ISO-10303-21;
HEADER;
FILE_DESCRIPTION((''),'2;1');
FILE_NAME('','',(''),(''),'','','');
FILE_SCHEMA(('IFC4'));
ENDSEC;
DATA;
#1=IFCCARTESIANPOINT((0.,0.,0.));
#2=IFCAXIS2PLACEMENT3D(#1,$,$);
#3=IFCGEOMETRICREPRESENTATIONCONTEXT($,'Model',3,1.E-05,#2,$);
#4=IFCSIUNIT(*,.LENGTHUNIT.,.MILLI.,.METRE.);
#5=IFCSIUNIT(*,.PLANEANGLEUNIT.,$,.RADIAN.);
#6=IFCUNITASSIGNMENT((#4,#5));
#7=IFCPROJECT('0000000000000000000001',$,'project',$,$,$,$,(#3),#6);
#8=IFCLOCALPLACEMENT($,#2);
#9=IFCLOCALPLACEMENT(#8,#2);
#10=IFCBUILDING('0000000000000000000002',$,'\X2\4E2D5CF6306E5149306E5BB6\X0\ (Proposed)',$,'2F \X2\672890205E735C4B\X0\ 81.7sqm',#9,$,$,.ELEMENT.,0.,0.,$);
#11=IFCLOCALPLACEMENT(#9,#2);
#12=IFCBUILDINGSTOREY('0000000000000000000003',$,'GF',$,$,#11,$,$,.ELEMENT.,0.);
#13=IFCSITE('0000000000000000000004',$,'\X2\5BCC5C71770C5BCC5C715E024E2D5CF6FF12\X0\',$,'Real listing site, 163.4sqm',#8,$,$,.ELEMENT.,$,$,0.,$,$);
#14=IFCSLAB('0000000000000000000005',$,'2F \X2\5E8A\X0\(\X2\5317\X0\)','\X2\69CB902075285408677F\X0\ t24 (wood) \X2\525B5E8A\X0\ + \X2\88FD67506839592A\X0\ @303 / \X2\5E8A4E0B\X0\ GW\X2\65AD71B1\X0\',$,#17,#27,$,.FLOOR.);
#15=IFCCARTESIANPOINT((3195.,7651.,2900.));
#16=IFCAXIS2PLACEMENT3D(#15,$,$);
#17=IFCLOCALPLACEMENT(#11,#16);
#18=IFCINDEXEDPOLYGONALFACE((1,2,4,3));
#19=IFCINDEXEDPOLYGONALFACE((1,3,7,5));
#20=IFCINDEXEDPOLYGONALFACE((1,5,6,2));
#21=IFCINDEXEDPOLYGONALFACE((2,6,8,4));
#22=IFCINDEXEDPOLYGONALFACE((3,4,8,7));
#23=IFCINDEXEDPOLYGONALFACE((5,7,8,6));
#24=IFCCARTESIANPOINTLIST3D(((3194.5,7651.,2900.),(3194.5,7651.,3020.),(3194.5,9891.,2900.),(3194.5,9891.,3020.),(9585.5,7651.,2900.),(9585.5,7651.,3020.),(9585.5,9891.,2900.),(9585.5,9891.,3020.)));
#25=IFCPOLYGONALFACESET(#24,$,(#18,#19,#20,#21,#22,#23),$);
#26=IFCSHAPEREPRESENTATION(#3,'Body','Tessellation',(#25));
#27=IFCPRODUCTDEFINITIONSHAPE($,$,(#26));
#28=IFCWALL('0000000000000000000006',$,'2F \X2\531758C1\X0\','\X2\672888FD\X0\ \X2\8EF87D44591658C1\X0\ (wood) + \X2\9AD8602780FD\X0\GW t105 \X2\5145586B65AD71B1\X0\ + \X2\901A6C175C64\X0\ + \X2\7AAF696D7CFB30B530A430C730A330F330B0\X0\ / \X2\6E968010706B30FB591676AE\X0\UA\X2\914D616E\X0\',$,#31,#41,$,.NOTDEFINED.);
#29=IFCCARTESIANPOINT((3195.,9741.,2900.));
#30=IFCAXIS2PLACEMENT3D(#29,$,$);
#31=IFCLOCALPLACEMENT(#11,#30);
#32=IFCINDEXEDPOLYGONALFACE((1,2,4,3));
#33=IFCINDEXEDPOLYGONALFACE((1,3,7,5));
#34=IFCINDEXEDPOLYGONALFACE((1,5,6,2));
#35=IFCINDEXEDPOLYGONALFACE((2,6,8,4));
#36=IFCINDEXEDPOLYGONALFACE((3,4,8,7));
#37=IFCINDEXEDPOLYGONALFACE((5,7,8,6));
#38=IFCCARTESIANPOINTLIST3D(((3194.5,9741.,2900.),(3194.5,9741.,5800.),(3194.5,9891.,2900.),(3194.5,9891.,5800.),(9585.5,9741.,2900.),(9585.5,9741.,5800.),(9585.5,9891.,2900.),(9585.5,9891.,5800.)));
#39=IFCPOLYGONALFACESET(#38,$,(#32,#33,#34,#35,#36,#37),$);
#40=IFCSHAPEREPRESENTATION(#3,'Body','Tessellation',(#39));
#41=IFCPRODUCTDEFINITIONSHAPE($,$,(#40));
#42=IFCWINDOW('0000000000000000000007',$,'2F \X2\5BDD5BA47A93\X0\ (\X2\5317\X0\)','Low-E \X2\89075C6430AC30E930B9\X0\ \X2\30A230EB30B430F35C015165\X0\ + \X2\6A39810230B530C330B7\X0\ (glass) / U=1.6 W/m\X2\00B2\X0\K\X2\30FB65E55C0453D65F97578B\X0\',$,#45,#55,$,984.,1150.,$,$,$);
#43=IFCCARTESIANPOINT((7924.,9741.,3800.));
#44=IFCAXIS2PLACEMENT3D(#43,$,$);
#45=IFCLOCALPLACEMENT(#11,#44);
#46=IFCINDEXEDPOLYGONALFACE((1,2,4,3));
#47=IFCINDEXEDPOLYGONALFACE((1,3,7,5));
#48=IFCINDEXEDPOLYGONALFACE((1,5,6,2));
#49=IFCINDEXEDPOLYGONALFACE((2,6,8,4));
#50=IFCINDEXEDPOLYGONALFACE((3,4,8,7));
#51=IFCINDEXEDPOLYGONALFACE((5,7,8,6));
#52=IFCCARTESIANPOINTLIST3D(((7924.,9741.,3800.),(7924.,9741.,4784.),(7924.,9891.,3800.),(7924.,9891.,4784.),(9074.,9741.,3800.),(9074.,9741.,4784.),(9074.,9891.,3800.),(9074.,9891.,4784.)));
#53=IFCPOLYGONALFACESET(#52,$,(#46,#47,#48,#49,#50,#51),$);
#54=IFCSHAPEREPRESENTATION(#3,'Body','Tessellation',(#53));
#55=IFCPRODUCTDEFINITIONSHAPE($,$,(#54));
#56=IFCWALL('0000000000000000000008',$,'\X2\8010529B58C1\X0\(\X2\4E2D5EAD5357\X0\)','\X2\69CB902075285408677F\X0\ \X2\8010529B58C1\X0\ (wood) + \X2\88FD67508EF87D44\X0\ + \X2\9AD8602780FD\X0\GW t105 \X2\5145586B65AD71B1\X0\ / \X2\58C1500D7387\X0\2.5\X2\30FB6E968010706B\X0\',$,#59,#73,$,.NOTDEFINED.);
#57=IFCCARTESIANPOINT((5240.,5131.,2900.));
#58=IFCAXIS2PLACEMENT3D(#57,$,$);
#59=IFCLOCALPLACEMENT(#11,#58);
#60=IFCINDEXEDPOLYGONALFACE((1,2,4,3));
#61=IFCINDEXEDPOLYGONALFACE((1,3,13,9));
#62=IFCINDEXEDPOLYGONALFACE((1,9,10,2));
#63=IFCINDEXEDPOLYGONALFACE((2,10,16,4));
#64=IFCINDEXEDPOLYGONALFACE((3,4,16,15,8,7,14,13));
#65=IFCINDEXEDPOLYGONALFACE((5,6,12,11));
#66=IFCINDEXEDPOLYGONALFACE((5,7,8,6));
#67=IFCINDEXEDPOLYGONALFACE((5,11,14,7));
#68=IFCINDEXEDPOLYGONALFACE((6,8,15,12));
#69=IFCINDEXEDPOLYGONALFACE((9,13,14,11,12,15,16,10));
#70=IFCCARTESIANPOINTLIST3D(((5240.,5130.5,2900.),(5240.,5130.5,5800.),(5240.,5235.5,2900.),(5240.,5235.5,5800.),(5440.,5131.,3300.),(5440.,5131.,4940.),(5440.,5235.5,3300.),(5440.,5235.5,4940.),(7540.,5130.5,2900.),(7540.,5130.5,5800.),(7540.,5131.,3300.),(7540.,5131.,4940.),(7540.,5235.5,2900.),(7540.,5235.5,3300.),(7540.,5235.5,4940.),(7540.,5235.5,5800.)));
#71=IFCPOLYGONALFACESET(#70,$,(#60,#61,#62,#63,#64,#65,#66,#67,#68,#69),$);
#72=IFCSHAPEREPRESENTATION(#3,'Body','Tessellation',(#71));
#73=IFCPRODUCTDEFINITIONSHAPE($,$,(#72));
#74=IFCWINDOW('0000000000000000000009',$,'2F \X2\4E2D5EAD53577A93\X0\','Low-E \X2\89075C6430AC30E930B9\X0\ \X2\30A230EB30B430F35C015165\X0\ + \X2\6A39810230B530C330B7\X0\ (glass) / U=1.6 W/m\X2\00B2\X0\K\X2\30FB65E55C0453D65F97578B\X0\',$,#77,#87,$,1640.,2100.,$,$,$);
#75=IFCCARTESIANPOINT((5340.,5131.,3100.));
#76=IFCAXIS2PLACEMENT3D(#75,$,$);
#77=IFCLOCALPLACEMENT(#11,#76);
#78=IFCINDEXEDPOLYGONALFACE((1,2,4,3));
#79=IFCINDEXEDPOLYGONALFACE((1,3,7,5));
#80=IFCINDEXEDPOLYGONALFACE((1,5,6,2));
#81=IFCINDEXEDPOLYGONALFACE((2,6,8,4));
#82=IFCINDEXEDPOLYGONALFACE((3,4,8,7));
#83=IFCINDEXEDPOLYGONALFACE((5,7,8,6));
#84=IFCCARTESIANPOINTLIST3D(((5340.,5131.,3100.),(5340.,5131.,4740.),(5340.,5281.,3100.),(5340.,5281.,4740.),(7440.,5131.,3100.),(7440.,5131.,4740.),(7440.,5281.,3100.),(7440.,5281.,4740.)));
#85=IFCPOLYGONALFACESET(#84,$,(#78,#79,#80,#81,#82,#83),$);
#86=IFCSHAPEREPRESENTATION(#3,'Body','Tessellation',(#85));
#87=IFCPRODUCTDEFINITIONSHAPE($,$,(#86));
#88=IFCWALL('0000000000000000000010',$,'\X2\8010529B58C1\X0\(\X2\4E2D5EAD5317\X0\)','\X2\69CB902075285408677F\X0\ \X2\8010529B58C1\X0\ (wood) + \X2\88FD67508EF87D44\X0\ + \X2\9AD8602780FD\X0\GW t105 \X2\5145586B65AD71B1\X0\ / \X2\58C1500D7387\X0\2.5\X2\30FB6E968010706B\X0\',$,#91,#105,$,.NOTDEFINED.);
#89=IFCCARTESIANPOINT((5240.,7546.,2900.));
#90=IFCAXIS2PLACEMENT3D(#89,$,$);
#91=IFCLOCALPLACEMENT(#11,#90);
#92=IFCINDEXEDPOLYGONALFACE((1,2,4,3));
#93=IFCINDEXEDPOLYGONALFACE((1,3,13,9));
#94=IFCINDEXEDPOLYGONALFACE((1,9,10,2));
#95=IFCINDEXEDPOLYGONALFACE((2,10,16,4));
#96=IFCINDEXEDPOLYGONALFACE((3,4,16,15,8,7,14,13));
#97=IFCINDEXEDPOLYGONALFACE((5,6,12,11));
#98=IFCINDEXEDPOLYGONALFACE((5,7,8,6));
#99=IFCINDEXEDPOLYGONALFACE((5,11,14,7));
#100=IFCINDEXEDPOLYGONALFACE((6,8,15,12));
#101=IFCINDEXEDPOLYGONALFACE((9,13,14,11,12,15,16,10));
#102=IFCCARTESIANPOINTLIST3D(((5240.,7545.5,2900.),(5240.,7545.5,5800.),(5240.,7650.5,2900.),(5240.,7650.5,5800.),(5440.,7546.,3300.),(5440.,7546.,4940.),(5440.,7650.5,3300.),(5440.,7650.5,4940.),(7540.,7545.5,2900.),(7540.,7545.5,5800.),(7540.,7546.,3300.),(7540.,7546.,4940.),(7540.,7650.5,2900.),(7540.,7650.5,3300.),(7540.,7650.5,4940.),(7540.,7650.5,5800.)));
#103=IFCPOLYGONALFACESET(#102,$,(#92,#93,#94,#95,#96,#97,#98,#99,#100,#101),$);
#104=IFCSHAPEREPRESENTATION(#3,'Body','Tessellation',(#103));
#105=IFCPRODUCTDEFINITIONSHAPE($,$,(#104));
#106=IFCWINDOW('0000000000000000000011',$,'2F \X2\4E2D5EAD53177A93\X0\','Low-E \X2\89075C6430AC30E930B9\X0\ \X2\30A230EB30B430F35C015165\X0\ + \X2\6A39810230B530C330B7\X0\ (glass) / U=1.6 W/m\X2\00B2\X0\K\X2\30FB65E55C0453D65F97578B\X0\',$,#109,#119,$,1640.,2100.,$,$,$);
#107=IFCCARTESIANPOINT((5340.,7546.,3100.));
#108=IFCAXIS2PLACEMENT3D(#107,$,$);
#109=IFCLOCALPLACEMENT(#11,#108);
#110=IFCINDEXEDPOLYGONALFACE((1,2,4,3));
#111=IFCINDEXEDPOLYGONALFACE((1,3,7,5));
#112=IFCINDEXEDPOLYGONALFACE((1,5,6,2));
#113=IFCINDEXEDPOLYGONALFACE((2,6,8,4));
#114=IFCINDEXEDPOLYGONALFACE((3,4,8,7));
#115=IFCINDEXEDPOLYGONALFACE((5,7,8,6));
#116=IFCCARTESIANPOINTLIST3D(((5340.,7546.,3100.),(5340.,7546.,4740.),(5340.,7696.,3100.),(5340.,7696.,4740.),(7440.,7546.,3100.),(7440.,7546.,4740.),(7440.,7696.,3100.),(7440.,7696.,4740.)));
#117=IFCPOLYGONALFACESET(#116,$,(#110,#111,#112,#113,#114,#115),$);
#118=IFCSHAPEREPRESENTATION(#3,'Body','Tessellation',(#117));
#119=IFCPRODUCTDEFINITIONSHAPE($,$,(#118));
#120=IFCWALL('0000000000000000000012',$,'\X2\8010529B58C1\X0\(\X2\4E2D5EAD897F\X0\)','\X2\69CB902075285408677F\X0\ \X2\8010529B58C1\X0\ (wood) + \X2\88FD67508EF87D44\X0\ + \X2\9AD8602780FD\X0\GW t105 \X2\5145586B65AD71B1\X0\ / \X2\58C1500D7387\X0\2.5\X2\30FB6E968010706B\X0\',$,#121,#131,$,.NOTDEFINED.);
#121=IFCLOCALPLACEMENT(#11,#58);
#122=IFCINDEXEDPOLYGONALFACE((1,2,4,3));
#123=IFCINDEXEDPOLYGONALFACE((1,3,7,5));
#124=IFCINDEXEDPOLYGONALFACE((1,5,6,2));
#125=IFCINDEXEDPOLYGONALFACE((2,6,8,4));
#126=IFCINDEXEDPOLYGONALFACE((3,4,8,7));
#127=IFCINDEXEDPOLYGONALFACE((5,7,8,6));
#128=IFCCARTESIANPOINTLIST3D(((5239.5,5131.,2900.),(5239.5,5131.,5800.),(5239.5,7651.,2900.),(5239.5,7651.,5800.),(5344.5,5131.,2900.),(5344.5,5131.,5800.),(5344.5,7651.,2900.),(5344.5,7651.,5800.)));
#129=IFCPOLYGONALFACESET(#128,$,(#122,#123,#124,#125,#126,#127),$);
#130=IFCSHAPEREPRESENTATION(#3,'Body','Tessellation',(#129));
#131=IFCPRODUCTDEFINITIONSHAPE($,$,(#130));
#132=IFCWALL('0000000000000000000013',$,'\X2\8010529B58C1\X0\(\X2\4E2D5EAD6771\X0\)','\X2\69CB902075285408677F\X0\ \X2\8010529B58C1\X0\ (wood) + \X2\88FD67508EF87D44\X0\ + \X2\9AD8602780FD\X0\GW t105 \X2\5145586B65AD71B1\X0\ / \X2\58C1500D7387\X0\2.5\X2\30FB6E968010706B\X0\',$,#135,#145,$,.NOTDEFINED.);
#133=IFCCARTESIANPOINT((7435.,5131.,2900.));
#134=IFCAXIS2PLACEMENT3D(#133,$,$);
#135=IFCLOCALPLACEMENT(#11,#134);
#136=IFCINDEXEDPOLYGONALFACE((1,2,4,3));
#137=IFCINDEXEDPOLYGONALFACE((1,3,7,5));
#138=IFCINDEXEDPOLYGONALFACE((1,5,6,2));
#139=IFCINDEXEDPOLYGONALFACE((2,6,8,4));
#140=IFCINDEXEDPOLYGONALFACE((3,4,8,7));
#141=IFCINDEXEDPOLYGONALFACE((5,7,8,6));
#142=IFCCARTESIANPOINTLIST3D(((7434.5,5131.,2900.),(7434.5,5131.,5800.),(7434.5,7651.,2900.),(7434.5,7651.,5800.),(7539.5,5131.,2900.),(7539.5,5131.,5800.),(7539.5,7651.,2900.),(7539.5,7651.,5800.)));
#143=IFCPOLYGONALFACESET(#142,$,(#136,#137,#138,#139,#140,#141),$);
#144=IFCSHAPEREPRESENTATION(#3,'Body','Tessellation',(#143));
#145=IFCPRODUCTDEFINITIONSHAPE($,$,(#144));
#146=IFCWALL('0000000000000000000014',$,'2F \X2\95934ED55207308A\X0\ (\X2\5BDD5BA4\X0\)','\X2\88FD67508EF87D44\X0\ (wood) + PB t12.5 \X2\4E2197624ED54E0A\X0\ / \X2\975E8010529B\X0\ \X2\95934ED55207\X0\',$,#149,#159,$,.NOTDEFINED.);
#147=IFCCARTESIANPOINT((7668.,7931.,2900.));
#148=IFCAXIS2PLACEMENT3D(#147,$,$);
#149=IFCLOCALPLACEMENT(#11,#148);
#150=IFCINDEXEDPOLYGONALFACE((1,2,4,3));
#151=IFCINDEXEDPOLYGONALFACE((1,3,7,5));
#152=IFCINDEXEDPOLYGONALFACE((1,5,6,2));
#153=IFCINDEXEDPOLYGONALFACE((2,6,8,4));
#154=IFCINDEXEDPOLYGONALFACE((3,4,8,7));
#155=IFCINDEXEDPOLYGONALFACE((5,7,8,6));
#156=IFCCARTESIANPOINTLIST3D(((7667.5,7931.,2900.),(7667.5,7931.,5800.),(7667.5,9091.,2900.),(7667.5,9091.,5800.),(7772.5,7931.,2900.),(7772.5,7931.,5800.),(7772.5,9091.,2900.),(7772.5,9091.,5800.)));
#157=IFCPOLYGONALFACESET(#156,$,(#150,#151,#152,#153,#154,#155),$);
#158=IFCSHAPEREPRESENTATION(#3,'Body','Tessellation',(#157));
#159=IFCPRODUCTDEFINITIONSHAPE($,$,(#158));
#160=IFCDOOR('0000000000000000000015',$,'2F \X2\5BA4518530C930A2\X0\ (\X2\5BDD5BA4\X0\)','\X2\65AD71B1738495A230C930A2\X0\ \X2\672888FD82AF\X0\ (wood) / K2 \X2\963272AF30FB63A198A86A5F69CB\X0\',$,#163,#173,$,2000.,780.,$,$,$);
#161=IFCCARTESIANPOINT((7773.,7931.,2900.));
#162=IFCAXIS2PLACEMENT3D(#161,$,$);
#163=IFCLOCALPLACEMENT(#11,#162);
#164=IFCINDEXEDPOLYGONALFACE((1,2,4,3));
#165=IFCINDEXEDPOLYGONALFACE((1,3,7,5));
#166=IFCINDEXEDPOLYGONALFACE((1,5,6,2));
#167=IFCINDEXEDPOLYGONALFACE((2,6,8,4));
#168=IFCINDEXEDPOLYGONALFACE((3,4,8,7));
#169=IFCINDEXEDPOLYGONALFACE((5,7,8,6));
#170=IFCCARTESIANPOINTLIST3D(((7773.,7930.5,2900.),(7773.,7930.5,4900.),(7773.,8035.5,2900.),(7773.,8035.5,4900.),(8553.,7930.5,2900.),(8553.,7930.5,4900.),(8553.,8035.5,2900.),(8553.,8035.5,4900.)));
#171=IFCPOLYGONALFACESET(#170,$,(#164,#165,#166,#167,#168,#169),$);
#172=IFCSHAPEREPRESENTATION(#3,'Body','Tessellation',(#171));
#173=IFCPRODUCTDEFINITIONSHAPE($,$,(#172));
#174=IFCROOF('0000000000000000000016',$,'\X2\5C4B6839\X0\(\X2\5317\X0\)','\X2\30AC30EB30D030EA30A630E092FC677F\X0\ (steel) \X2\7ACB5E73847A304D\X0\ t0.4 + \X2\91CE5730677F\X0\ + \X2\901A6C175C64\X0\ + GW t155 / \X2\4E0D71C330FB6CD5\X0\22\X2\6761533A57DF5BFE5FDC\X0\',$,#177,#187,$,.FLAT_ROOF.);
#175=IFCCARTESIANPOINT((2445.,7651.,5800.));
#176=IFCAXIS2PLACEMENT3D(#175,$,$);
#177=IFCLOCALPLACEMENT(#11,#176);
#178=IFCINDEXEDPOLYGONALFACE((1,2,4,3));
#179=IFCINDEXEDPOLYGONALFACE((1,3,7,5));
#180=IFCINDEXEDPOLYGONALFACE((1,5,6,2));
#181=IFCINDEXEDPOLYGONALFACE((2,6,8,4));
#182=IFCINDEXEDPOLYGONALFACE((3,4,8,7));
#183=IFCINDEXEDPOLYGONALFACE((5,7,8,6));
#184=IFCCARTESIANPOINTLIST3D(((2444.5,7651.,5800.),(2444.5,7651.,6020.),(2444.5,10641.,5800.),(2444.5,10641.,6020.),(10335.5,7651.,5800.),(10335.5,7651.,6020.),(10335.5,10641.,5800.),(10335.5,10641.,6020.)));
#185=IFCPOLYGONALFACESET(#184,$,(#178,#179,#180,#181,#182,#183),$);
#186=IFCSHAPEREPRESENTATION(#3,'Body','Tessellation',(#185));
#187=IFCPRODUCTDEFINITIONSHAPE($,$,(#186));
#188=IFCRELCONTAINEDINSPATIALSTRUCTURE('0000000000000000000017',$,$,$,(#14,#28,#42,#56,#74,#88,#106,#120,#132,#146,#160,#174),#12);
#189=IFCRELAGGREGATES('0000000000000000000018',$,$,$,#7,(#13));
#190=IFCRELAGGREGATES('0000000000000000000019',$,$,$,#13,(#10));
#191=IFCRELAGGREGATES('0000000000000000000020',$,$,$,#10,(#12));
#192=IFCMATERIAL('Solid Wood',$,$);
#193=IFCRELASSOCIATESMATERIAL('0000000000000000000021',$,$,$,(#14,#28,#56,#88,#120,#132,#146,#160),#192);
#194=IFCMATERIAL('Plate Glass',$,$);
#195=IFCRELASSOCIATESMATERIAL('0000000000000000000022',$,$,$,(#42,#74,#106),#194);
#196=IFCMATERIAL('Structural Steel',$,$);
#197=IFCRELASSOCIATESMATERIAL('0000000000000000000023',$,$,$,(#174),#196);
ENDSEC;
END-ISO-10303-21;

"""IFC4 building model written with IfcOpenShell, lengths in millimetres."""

from ifc_helpers import new_model, si_unit, frame, frame_2d, origin, place, context, project, spatial, rectangle, extrude, material, element, fill, save


model = new_model("IFC4")

# Units and contexts
model_context = context("Model", 3, precision=1e-05, world=origin())
ifc_project = project(units=[si_unit("LENGTHUNIT", "METRE", prefix="MILLI"), si_unit("PLANEANGLEUNIT", "RADIAN")], contexts=[model_context])

# Site, building, storey
site_placement = place(None, origin())
site = spatial("IfcSite", under=ifc_project, at=site_placement, Name="富山県富山市中島２", ObjectType="Real listing site, 163.4sqm", CompositionType="ELEMENT", RefElevation=0.0)
building_placement = place(site_placement, origin())
building = spatial("IfcBuilding", under=site, at=building_placement, Name="中島の光の家 (Proposed)", ObjectType="2F 木造平屋 81.7sqm", CompositionType="ELEMENT", ElevationOfRefHeight=0.0, ElevationOfTerrain=0.0)
storey_placement = place(building_placement, origin())
storey = spatial("IfcBuildingStorey", under=building, at=storey_placement, Name="GF", CompositionType="ELEMENT", Elevation=0.0)

# Slab
ifc_material_1 = material(Name="Solid Wood")
slab_placement = place(storey_placement, frame((3195.0, 7651.0, 2900.0)))
element("IfcSlab", 1, at=slab_placement, inside=storey, material=ifc_material_1, Name="2F 床(北)", Description="構造用合板 t24 (wood) 剛床 + 製材根太 @303 / 床下 GW断熱", PredefinedType="FLOOR", context=model_context, shape_type="SweptSolid", body=[
    extrude(rectangle(XDim=6391.0, YDim=2240.0, at=frame_2d((3195.0, 1120.0))), frame((3195.0, 7651.0, 2900.0)), (0.0, 0.0, 1.0), 120.0),
])

# Walls, openings, windows
wall_1_placement = place(storey_placement, frame((3195.0, 9741.0, 2900.0)))
wall_1 = element("IfcWall", 2, at=wall_1_placement, inside=storey, material=ifc_material_1, Name="2F 北壁", Description="木製 軸組外壁 (wood) + 高性能GW t105 充填断熱 + 通気層 + 窯業系サイディング / 準耐火・外皮UA配慮", PredefinedType="NOTDEFINED", context=model_context, shape_type="SweptSolid", body=[
    extrude(rectangle(XDim=6391.0, YDim=150.0, at=frame_2d((3195.0, 75.0))), frame((3195.0, 9741.0, 2900.0)), (0.0, 0.0, 1.0), 2900.0),
])
opening_1_placement = place(storey_placement, frame((7924.0, 9741.0, 3800.0)))
opening_1 = element("IfcOpeningElement", 3, at=opening_1_placement, cuts=wall_1, PredefinedType="NOTDEFINED", context=model_context, shape_type="SweptSolid", body=[
    extrude(rectangle(XDim=1150.0, YDim=150.0, at=frame_2d((575.0, 75.0))), frame((7924.0, 9741.0, 3800.0)), (0.0, 0.0, 1.0), 984.0),
])
ifc_material_2 = material(Name="Plate Glass")
window_1_placement = place(storey_placement, frame((7924.0, 9741.0, 3800.0)))
window_1 = element("IfcWindow", 4, at=window_1_placement, inside=storey, material=ifc_material_2, Name="2F 寝室窓 (北)", Description="Low-E 複層ガラス アルゴン封入 + 樹脂サッシ (glass) / U=1.6 W/m²K・日射取得型", OverallHeight=984.0, OverallWidth=1150.0, context=model_context, shape_type="SweptSolid", body=[
    extrude(rectangle(XDim=1150.0, YDim=150.0, at=frame_2d((575.0, 75.0))), frame((7924.0, 9741.0, 3800.0)), (0.0, 0.0, 1.0), 984.0),
])
fill(opening_1, window_1)
wall_2_placement = place(storey_placement, frame((5240.0, 5131.0, 2900.0)))
wall_2 = element("IfcWall", 5, at=wall_2_placement, inside=storey, material=ifc_material_1, Name="耐力壁(中庭南)", Description="構造用合板 耐力壁 (wood) + 製材軸組 + 高性能GW t105 充填断熱 / 壁倍率2.5・準耐火", PredefinedType="NOTDEFINED", context=model_context, shape_type="SweptSolid", body=[
    extrude(rectangle(XDim=2300.0, YDim=105.0, at=frame_2d((1150.0, 52.0))), frame((5240.0, 5131.0, 2900.0)), (0.0, 0.0, 1.0), 2900.0),
])
opening_2_placement = place(storey_placement, frame((5340.0, 5131.0, 3100.0)))
opening_2 = element("IfcOpeningElement", 6, at=opening_2_placement, cuts=wall_2, PredefinedType="NOTDEFINED", context=model_context, shape_type="SweptSolid", body=[
    extrude(rectangle(XDim=2100.0, YDim=150.0, at=frame_2d((1050.0, 75.0))), frame((5340.0, 5131.0, 3100.0)), (0.0, 0.0, 1.0), 1640.0),
])
window_2_placement = place(storey_placement, frame((5340.0, 5131.0, 3100.0)))
window_2 = element("IfcWindow", 7, at=window_2_placement, inside=storey, material=ifc_material_2, Name="2F 中庭南窓", Description="Low-E 複層ガラス アルゴン封入 + 樹脂サッシ (glass) / U=1.6 W/m²K・日射取得型", OverallHeight=1640.0, OverallWidth=2100.0, context=model_context, shape_type="SweptSolid", body=[
    extrude(rectangle(XDim=2100.0, YDim=150.0, at=frame_2d((1050.0, 75.0))), frame((5340.0, 5131.0, 3100.0)), (0.0, 0.0, 1.0), 1640.0),
])
fill(opening_2, window_2)
wall_3_placement = place(storey_placement, frame((5240.0, 7546.0, 2900.0)))
wall_3 = element("IfcWall", 8, at=wall_3_placement, inside=storey, material=ifc_material_1, Name="耐力壁(中庭北)", Description="構造用合板 耐力壁 (wood) + 製材軸組 + 高性能GW t105 充填断熱 / 壁倍率2.5・準耐火", PredefinedType="NOTDEFINED", context=model_context, shape_type="SweptSolid", body=[
    extrude(rectangle(XDim=2300.0, YDim=105.0, at=frame_2d((1150.0, 52.0))), frame((5240.0, 7546.0, 2900.0)), (0.0, 0.0, 1.0), 2900.0),
])
opening_3_placement = place(storey_placement, frame((5340.0, 7546.0, 3100.0)))
opening_3 = element("IfcOpeningElement", 9, at=opening_3_placement, cuts=wall_3, PredefinedType="NOTDEFINED", context=model_context, shape_type="SweptSolid", body=[
    extrude(rectangle(XDim=2100.0, YDim=150.0, at=frame_2d((1050.0, 75.0))), frame((5340.0, 7546.0, 3100.0)), (0.0, 0.0, 1.0), 1640.0),
])
window_3_placement = place(storey_placement, frame((5340.0, 7546.0, 3100.0)))
window_3 = element("IfcWindow", 10, at=window_3_placement, inside=storey, material=ifc_material_2, Name="2F 中庭北窓", Description="Low-E 複層ガラス アルゴン封入 + 樹脂サッシ (glass) / U=1.6 W/m²K・日射取得型", OverallHeight=1640.0, OverallWidth=2100.0, context=model_context, shape_type="SweptSolid", body=[
    extrude(rectangle(XDim=2100.0, YDim=150.0, at=frame_2d((1050.0, 75.0))), frame((5340.0, 7546.0, 3100.0)), (0.0, 0.0, 1.0), 1640.0),
])
fill(opening_3, window_3)

# Walls
wall_4_placement = place(storey_placement, frame((5240.0, 5131.0, 2900.0)))
element("IfcWall", 11, at=wall_4_placement, inside=storey, material=ifc_material_1, Name="耐力壁(中庭西)", Description="構造用合板 耐力壁 (wood) + 製材軸組 + 高性能GW t105 充填断熱 / 壁倍率2.5・準耐火", PredefinedType="NOTDEFINED", context=model_context, shape_type="SweptSolid", body=[
    extrude(rectangle(XDim=105.0, YDim=2520.0, at=frame_2d((52.0, 1260.0))), frame((5240.0, 5131.0, 2900.0)), (0.0, 0.0, 1.0), 2900.0),
])
wall_5_placement = place(storey_placement, frame((7435.0, 5131.0, 2900.0)))
element("IfcWall", 12, at=wall_5_placement, inside=storey, material=ifc_material_1, Name="耐力壁(中庭東)", Description="構造用合板 耐力壁 (wood) + 製材軸組 + 高性能GW t105 充填断熱 / 壁倍率2.5・準耐火", PredefinedType="NOTDEFINED", context=model_context, shape_type="SweptSolid", body=[
    extrude(rectangle(XDim=105.0, YDim=2520.0, at=frame_2d((52.0, 1260.0))), frame((7435.0, 5131.0, 2900.0)), (0.0, 0.0, 1.0), 2900.0),
])
wall_6_placement = place(storey_placement, frame((7668.0, 7931.0, 2900.0)))
element("IfcWall", 13, at=wall_6_placement, inside=storey, material=ifc_material_1, Name="2F 間仕切り (寝室)", Description="製材軸組 (wood) + PB t12.5 両面仕上 / 非耐力 間仕切", PredefinedType="NOTDEFINED", context=model_context, shape_type="SweptSolid", body=[
    extrude(rectangle(XDim=105.0, YDim=1160.0, at=frame_2d((52.0, 580.0))), frame((7668.0, 7931.0, 2900.0)), (0.0, 0.0, 1.0), 2900.0),
])

# Door
door_placement = place(storey_placement, frame((7773.0, 7931.0, 2900.0)))
element("IfcDoor", 14, at=door_placement, inside=storey, material=ifc_material_1, Name="2F 室内ドア (寝室)", Description="断熱玄関ドア 木製芯 (wood) / K2 防犯・採風機構", OverallHeight=2000.0, OverallWidth=780.0, context=model_context, shape_type="SweptSolid", body=[
    extrude(rectangle(XDim=780.0, YDim=105.0, at=frame_2d((390.0, 52.0))), frame((7773.0, 7931.0, 2900.0)), (0.0, 0.0, 1.0), 2000.0),
])

# Roof
ifc_material_3 = material(Name="Structural Steel")
for number, where, name in (
    (15, (2445.0, 7651.0, 5800.0), "屋根(北)"),
):
    element("IfcRoof", number, at=place(storey_placement, frame(where)), inside=storey, material=ifc_material_3, Name=name, Description="ガルバリウム鋼板 (steel) 立平葺き t0.4 + 野地板 + 通気層 + GW t155 / 不燃・法22条区域対応", PredefinedType="FLAT_ROOF", context=model_context, shape_type="SweptSolid", body=[
        extrude(rectangle(XDim=7891.0, YDim=2990.0, at=frame_2d((3945.0, 1495.0))), frame((2445.0, 7651.0, 5800.0)), (0.0, 0.0, 1.0), 220.0),
    ])

save(model, "model.ifc")
